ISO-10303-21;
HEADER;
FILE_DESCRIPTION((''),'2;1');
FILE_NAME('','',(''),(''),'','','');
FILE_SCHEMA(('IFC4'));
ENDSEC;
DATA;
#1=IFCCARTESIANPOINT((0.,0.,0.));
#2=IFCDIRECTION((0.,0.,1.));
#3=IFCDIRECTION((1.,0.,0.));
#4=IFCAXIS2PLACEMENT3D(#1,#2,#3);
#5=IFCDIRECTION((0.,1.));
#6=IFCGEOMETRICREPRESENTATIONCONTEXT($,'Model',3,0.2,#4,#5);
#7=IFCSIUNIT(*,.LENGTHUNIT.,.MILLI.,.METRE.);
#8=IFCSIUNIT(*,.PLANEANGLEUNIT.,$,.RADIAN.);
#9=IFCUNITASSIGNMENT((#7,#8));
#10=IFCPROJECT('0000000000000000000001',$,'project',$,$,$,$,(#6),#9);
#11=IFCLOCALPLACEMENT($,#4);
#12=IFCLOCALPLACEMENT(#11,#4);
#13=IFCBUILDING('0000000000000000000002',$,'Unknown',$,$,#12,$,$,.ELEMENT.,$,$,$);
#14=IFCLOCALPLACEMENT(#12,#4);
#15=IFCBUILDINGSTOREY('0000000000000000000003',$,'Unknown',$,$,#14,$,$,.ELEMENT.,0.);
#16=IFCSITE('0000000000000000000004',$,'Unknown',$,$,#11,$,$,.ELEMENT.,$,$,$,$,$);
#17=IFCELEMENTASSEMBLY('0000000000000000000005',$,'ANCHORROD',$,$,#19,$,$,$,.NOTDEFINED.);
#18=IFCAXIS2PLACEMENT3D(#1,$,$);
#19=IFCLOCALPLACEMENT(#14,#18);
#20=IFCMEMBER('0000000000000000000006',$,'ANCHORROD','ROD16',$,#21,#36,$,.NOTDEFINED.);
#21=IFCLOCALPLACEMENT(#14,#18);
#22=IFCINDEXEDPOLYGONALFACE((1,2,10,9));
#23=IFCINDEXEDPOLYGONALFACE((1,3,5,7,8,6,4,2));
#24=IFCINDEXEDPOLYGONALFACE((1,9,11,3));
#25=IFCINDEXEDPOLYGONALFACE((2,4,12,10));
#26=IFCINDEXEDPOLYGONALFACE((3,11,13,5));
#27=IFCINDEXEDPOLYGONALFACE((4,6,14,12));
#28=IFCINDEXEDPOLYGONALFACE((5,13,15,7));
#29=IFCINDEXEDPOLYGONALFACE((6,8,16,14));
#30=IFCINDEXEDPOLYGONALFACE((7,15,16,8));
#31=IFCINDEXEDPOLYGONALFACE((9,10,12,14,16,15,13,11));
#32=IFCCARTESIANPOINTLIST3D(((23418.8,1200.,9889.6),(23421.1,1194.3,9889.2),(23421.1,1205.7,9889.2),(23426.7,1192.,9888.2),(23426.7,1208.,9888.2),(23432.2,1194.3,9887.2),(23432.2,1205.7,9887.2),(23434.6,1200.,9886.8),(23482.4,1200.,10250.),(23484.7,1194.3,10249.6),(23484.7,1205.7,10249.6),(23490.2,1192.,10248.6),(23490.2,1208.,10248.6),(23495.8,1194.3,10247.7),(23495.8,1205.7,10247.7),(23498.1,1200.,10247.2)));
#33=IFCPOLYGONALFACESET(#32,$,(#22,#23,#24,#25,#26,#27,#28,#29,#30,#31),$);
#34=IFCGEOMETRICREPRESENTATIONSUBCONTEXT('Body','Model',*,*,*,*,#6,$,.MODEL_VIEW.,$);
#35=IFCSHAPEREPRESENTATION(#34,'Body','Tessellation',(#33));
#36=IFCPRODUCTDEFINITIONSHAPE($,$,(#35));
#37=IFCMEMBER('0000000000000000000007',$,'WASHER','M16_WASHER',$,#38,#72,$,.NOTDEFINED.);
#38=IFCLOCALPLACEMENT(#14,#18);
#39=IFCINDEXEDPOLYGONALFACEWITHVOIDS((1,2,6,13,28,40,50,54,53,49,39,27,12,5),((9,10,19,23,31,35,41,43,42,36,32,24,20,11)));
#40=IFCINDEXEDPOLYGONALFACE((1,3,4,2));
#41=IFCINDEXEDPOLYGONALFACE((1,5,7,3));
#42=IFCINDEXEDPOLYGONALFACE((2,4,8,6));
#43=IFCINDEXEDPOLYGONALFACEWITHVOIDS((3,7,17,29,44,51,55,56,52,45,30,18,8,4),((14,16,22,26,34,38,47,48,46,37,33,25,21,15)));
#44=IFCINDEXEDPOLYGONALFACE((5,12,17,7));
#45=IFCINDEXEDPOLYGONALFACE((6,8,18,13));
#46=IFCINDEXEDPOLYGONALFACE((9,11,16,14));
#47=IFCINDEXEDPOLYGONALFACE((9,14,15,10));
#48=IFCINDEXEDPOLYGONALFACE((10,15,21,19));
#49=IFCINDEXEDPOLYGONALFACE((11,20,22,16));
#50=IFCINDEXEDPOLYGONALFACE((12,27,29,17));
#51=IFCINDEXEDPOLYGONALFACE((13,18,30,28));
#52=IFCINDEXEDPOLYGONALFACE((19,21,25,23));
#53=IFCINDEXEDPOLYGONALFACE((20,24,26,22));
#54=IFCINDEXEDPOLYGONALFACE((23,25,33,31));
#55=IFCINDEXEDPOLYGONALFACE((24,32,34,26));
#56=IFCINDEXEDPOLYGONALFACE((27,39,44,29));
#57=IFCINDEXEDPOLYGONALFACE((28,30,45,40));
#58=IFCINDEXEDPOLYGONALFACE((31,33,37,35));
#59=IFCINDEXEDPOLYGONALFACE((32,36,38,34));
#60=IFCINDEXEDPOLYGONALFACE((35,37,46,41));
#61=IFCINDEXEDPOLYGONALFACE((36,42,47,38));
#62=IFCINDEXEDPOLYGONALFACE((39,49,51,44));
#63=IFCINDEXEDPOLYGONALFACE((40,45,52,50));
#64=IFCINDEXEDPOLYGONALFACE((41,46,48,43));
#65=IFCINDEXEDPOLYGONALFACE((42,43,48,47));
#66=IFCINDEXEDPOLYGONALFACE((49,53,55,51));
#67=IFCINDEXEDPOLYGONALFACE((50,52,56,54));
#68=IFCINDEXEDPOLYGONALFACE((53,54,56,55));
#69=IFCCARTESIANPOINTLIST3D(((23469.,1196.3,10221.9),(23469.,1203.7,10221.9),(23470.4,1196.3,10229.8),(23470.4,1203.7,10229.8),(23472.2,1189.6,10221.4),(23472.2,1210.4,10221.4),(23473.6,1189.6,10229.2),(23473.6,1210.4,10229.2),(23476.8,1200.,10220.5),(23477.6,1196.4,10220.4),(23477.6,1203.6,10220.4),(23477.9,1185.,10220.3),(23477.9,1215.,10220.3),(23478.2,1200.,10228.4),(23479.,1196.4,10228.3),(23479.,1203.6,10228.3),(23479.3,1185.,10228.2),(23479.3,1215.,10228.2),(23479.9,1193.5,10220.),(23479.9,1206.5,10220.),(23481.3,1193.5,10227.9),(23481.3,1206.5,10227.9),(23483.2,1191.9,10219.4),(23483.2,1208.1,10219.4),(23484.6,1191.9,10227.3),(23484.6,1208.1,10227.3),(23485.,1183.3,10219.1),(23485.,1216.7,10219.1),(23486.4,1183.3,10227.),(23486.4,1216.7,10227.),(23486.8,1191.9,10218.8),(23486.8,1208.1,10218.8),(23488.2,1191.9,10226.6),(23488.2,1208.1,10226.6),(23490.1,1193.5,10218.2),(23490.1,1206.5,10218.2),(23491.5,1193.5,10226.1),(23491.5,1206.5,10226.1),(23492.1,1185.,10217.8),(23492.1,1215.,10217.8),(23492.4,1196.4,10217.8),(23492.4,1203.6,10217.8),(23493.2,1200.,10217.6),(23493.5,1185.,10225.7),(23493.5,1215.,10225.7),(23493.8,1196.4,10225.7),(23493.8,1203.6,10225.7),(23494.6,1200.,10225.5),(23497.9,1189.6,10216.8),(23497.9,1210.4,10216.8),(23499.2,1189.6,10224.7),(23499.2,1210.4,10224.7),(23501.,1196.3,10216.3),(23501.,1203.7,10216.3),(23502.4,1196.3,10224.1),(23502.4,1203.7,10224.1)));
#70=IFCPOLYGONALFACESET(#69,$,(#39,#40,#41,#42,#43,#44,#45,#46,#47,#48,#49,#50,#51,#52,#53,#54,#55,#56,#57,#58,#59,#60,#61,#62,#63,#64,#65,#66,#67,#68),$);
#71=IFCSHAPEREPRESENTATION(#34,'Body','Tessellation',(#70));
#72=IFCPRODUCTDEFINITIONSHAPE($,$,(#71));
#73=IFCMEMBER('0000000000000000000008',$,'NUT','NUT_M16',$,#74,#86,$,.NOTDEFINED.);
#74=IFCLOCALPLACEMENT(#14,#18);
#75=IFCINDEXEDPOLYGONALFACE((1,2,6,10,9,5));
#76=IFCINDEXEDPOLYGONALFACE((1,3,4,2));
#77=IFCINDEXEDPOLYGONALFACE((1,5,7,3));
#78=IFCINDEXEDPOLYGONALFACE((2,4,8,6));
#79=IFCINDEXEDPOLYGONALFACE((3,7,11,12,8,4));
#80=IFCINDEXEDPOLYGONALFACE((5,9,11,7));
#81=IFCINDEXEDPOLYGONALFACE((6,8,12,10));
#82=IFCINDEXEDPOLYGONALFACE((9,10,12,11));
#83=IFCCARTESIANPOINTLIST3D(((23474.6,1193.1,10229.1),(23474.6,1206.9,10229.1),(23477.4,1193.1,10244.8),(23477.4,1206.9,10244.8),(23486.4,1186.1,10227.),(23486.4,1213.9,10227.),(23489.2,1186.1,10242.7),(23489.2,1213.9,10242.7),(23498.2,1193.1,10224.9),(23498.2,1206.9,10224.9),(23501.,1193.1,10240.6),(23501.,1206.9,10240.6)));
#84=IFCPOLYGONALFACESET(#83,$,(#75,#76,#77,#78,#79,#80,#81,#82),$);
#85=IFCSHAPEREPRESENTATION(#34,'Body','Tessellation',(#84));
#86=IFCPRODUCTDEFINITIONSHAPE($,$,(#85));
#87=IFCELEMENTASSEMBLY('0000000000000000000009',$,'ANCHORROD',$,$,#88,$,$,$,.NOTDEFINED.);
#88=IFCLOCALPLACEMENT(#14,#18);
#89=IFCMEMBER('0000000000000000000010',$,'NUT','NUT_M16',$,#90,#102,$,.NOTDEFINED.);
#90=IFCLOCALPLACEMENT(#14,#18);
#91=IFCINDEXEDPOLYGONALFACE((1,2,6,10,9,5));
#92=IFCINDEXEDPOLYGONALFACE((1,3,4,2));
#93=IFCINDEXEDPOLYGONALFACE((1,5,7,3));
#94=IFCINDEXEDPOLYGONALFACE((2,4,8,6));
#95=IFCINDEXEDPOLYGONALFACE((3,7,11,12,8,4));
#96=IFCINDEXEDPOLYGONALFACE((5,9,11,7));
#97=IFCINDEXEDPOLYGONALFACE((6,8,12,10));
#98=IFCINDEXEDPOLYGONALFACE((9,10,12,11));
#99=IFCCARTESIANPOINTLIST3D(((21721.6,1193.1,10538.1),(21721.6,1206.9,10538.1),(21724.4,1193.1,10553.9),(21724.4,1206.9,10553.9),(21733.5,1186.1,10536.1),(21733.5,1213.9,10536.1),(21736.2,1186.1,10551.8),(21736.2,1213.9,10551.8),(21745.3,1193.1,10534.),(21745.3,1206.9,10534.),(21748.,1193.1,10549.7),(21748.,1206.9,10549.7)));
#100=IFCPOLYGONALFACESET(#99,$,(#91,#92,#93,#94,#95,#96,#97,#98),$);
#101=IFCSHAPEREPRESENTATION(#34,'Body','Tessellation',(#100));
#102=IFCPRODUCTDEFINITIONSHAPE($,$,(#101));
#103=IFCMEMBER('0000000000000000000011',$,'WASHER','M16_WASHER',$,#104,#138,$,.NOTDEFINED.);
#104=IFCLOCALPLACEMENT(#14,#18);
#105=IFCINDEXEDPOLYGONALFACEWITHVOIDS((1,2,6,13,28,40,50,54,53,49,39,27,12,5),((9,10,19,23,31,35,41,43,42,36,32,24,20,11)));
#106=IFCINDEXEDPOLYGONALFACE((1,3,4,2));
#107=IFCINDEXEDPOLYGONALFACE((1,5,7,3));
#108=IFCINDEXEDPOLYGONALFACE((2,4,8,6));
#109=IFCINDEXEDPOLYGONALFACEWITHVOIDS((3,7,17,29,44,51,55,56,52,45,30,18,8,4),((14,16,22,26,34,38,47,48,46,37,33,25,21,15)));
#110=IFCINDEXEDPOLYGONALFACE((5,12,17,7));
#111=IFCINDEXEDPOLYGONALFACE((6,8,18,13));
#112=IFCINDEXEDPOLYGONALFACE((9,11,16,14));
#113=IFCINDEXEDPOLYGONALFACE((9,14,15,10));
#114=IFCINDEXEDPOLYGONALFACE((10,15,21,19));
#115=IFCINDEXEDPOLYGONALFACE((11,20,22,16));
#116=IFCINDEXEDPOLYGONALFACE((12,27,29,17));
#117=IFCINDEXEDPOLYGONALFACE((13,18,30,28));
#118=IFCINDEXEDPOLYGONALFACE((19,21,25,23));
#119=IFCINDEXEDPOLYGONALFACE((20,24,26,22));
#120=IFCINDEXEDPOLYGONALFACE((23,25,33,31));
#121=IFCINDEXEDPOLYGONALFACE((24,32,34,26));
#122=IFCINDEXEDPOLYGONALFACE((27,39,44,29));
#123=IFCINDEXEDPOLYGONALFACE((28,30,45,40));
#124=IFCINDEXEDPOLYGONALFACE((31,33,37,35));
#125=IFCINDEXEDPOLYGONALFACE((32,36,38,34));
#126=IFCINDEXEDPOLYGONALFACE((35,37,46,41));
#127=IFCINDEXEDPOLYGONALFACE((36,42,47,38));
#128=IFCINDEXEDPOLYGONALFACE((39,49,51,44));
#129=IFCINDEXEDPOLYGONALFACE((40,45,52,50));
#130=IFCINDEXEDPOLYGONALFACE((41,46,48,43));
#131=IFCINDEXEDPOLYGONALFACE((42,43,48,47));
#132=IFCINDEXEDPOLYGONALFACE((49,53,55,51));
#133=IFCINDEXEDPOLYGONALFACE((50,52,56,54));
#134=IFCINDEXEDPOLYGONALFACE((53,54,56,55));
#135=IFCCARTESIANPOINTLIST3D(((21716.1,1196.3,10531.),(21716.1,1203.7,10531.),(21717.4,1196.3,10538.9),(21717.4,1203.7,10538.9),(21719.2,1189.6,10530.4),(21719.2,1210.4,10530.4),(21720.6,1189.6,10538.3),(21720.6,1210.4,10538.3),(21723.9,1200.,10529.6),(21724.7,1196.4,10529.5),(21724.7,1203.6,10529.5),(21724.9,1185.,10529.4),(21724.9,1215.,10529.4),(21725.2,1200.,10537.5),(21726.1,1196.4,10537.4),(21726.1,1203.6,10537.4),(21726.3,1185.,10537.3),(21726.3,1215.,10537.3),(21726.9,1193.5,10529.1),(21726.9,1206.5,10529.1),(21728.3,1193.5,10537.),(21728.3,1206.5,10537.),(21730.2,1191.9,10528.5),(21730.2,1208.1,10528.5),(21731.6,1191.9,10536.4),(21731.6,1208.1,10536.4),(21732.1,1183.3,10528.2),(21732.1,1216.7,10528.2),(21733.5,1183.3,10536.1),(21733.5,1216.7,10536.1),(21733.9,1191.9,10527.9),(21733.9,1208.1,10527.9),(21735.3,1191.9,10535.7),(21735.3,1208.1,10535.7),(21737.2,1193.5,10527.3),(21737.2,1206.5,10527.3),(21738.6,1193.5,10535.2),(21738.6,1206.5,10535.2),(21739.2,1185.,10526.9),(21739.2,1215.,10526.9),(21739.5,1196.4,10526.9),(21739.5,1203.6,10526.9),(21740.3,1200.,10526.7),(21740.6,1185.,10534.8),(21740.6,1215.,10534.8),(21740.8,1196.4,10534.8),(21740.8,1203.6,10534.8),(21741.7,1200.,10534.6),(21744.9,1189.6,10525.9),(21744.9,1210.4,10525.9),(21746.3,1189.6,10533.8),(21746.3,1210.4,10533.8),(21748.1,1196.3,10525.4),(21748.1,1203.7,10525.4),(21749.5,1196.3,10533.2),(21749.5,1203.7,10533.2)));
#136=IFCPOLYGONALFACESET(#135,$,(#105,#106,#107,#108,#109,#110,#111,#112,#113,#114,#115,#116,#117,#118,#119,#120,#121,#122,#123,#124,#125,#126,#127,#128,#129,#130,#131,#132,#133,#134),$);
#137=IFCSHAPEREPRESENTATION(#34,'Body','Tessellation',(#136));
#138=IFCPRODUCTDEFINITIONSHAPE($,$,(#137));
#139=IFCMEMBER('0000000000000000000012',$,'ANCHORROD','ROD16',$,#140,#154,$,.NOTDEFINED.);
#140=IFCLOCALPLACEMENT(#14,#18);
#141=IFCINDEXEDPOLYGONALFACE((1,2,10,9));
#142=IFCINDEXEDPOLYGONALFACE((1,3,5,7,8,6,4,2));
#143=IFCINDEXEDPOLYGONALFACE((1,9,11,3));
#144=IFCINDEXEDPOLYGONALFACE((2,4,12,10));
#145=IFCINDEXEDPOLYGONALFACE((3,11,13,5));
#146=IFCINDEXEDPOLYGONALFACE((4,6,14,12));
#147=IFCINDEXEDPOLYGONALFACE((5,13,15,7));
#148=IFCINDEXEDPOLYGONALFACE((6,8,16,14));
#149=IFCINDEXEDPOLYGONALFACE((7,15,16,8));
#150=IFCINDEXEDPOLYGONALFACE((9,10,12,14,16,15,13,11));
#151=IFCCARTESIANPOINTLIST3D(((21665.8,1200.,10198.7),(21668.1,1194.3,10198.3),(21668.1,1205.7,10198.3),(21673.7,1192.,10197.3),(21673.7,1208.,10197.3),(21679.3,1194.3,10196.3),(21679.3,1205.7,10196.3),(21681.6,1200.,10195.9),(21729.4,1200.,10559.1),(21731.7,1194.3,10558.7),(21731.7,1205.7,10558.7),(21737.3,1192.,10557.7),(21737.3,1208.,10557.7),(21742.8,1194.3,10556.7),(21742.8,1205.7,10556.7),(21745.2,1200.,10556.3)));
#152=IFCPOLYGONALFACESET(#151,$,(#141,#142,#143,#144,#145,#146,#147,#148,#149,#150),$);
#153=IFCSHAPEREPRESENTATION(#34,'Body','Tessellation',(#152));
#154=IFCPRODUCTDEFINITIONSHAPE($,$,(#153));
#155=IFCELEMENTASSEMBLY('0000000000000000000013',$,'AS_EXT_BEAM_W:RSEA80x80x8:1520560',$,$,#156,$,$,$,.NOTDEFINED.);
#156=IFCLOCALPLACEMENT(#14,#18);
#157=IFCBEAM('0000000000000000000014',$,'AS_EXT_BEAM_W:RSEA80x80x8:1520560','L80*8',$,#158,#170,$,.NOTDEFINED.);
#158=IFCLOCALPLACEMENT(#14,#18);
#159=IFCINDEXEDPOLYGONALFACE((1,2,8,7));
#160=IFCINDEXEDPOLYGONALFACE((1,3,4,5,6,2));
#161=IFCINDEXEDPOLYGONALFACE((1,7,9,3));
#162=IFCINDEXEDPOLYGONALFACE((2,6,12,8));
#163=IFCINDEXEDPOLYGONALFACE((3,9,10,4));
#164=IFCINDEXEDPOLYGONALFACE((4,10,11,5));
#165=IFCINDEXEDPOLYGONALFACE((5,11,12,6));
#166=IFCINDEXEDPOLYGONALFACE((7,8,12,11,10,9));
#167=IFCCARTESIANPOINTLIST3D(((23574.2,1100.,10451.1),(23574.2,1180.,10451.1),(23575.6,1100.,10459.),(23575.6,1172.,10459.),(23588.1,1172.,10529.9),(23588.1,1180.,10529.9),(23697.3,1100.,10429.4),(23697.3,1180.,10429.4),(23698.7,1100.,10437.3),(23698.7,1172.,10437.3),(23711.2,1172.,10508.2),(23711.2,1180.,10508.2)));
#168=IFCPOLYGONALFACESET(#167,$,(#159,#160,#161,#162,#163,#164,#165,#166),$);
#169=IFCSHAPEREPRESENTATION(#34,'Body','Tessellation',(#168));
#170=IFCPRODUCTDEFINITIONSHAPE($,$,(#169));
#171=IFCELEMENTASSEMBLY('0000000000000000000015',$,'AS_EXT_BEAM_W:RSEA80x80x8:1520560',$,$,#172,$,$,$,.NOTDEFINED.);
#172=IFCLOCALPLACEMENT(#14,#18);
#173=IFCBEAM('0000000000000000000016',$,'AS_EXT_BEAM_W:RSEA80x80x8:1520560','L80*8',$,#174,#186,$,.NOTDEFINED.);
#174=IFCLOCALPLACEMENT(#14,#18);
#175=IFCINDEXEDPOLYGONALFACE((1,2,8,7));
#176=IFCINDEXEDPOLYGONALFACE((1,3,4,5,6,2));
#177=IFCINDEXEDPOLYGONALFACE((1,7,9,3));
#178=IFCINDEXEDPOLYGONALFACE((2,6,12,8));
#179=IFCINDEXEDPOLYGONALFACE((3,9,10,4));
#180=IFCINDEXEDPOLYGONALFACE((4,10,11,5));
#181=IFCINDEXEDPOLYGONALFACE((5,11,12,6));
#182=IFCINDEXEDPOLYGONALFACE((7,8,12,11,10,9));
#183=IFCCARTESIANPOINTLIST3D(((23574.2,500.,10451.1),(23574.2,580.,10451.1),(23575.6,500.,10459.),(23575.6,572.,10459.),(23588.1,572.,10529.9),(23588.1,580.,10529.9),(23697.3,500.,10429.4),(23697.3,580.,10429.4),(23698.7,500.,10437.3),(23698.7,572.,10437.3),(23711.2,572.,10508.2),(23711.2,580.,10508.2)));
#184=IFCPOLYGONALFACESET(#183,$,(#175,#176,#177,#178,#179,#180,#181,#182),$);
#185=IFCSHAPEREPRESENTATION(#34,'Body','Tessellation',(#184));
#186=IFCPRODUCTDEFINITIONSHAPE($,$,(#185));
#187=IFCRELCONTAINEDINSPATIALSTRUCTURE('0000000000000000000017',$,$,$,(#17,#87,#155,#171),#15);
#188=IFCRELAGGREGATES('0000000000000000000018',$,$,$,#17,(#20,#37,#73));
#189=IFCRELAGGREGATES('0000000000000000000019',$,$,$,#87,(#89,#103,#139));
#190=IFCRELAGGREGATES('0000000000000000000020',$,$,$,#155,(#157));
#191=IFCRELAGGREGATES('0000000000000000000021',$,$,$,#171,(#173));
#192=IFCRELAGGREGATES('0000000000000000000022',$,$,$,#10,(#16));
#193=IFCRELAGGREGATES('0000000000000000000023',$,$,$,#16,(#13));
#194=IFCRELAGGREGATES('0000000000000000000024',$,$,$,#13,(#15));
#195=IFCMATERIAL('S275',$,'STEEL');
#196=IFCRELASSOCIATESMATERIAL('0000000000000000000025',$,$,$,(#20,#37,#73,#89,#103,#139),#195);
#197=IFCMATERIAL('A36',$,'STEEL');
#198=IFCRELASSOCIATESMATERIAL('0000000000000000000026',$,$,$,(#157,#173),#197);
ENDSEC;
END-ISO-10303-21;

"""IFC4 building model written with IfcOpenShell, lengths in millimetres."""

from ifc_helpers import new_model, si_unit, direction, frame, origin_with_axes, place, context, subcontext, project, spatial, line, indexed_curve, outline, extrude, material, element, aggregate, save


model = new_model("IFC4")

# Units and contexts
model_context = context("Model", 3, precision=0.2, world=origin_with_axes(), true_north=direction((0.0, 1.0)))
body_context = subcontext(model_context, "Body", "Model", "MODEL_VIEW")
ifc_project = project(units=[si_unit("LENGTHUNIT", "METRE", prefix="MILLI"), si_unit("PLANEANGLEUNIT", "RADIAN")], contexts=[model_context])

# Site, building, storey
site_placement = place(None, origin_with_axes())
site = spatial("IfcSite", under=ifc_project, at=site_placement, Name="Unknown", CompositionType="ELEMENT")
building_placement = place(site_placement, origin_with_axes())
building = spatial("IfcBuilding", under=site, at=building_placement, Name="Unknown", CompositionType="ELEMENT")
storey_placement = place(building_placement, origin_with_axes())
storey = spatial("IfcBuildingStorey", under=building, at=storey_placement, Name="Unknown", CompositionType="ELEMENT", Elevation=0.0)

# Element assemblies, members
assembly_1_placement = place(storey_placement, frame((23490.2, 1200.0, 10248.6), z_axis=(0.0, -1.0, 0.0), x_axis=(-0.173648, 0.0, -0.984808)))
assembly_1 = element("IfcElementAssembly", 1, at=assembly_1_placement, inside=storey, Name="ANCHORROD", PredefinedType="NOTDEFINED")
ifc_material_1 = material(Name="S275", Category="STEEL")
member_1_placement = place(assembly_1_placement, origin_with_axes())
member_1 = element("IfcMember", 2, at=member_1_placement, material=ifc_material_1, Name="ANCHORROD", Description="ROD16", PredefinedType="NOTDEFINED", context=body_context, shape_type="SolidModel", body=[
    extrude(outline(indexed_curve([(8.0, 0.0), (5.7, 5.7), (0.0, 8.0), (-5.7, 5.7), (-8.0, 0.0), (-5.7, -5.7), (0.0, -8.0), (5.7, -5.7)], segments=[line(1, 2, 3, 4, 5, 6, 7, 8, 1)])), frame((0.0, 0.0, 0.0), z_axis=(-1.0, 0.0, 0.0), x_axis=(0.0, 0.0, 1.0)), (0.0, 0.0, -1.0), 366.0),
])
member_2_placement = place(assembly_1_placement, frame((22.0, 0.0, 0.0), z_axis=(0.0, 0.0, 1.0), x_axis=(1.0, 0.0, 0.0)))
member_2 = element("IfcMember", 3, at=member_2_placement, material=ifc_material_1, Name="WASHER", Description="M16_WASHER", PredefinedType="NOTDEFINED", context=body_context, shape_type="SolidModel", body=[
    extrude(outline(indexed_curve([(16.7, 0.0), (15.0, 7.2), (10.4, 13.0), (3.7, 16.3), (-3.7, 16.3), (-10.4, 13.0), (-15.0, 7.2), (-16.7, 0.0), (-15.0, -7.2), (-10.4, -13.0), (-3.7, -16.3), (3.7, -16.3), (10.4, -13.0), (15.0, -7.2)], segments=[line(1, 2, 3, 4, 5, 6, 7, 8, 9, 10, 11, 12, 13, 14, 1)]), holes=[indexed_curve([(0.0, 8.3), (3.6, 7.5), (6.5, 5.2), (8.1, 1.9), (8.1, -1.9), (6.5, -5.2), (3.6, -7.5), (0.0, -8.3), (-3.6, -7.5), (-6.5, -5.2), (-8.1, -1.9), (-8.1, 1.9), (-6.5, 5.2), (-3.6, 7.5)], segments=[line(1, 2, 3, 4, 5, 6, 7, 8, 9, 10, 11, 12, 13, 14, 1)])]), frame((0.0, 0.0, 0.0), z_axis=(-1.0, 0.0, 0.0), x_axis=(0.0, 0.0, 1.0)), (0.0, 0.0, -1.0), 8.0),
])
member_3_placement = place(assembly_1_placement, frame((6.0, 0.0, 0.0), z_axis=(0.0, 0.0, 1.0), x_axis=(1.0, 0.0, 0.0)))
member_3 = element("IfcMember", 4, at=member_3_placement, material=ifc_material_1, Name="NUT", Description="NUT_M16", PredefinedType="NOTDEFINED", context=body_context, shape_type="SolidModel", body=[
    extrude(outline(indexed_curve([(6.9, -12.0), (13.9, 0.0), (6.9, 12.0), (-6.9, 12.0), (-13.9, 0.0), (-6.9, -12.0)], segments=[line(1, 2, 3, 4, 5, 6, 1)])), frame((0.0, 0.0, 0.0), z_axis=(-1.0, 0.0, 0.0), x_axis=(0.0, 0.0, 1.0)), (0.0, 0.0, -1.0), 16.0),
])
aggregate(assembly_1, [member_1, member_2, member_3])
assembly_2_placement = place(storey_placement, frame((21737.3, 1200.0, 10557.7), z_axis=(0.0, -1.0, 0.0), x_axis=(-0.173648, 0.0, -0.984808)))
assembly_2 = element("IfcElementAssembly", 5, at=assembly_2_placement, inside=storey, Name="ANCHORROD", PredefinedType="NOTDEFINED")
member_4_placement = place(assembly_2_placement, frame((6.0, 0.0, 0.0), z_axis=(0.0, 0.0, 1.0), x_axis=(1.0, 0.0, 0.0)))
member_4 = element("IfcMember", 6, at=member_4_placement, material=ifc_material_1, Name="NUT", Description="NUT_M16", PredefinedType="NOTDEFINED", context=body_context, shape_type="SolidModel", body=[
    extrude(outline(indexed_curve([(6.9, -12.0), (13.9, 0.0), (6.9, 12.0), (-6.9, 12.0), (-13.9, 0.0), (-6.9, -12.0)], segments=[line(1, 2, 3, 4, 5, 6, 1)])), frame((0.0, 0.0, 0.0), z_axis=(-1.0, 0.0, 0.0), x_axis=(0.0, 0.0, 1.0)), (0.0, 0.0, -1.0), 16.0),
])
member_5_placement = place(assembly_2_placement, frame((22.0, 0.0, 0.0), z_axis=(0.0, 0.0, 1.0), x_axis=(1.0, 0.0, 0.0)))
member_5 = element("IfcMember", 7, at=member_5_placement, material=ifc_material_1, Name="WASHER", Description="M16_WASHER", PredefinedType="NOTDEFINED", context=body_context, shape_type="SolidModel", body=[
    extrude(outline(indexed_curve([(16.7, 0.0), (15.0, 7.2), (10.4, 13.0), (3.7, 16.3), (-3.7, 16.3), (-10.4, 13.0), (-15.0, 7.2), (-16.7, 0.0), (-15.0, -7.2), (-10.4, -13.0), (-3.7, -16.3), (3.7, -16.3), (10.4, -13.0), (15.0, -7.2)], segments=[line(1, 2, 3, 4, 5, 6, 7, 8, 9, 10, 11, 12, 13, 14, 1)]), holes=[indexed_curve([(0.0, 8.3), (3.6, 7.5), (6.5, 5.2), (8.1, 1.9), (8.1, -1.9), (6.5, -5.2), (3.6, -7.5), (0.0, -8.3), (-3.6, -7.5), (-6.5, -5.2), (-8.1, -1.9), (-8.1, 1.9), (-6.5, 5.2), (-3.6, 7.5)], segments=[line(1, 2, 3, 4, 5, 6, 7, 8, 9, 10, 11, 12, 13, 14, 1)])]), frame((0.0, 0.0, 0.0), z_axis=(-1.0, 0.0, 0.0), x_axis=(0.0, 0.0, 1.0)), (0.0, 0.0, -1.0), 8.0),
])
member_6_placement = place(assembly_2_placement, origin_with_axes())
member_6 = element("IfcMember", 8, at=member_6_placement, material=ifc_material_1, Name="ANCHORROD", Description="ROD16", PredefinedType="NOTDEFINED", context=body_context, shape_type="SolidModel", body=[
    extrude(outline(indexed_curve([(8.0, 0.0), (5.7, 5.7), (0.0, 8.0), (-5.7, 5.7), (-8.0, 0.0), (-5.7, -5.7), (0.0, -8.0), (5.7, -5.7)], segments=[line(1, 2, 3, 4, 5, 6, 7, 8, 1)])), frame((0.0, 0.0, 0.0), z_axis=(-1.0, 0.0, 0.0), x_axis=(0.0, 0.0, 1.0)), (0.0, 0.0, -1.0), 366.0),
])
aggregate(assembly_2, [member_4, member_5, member_6])

# Element assemblies, beams
assembly_3_placement = place(storey_placement, frame((23581.1, 1140.0, 10490.5), z_axis=(0.0, -1.0, 0.0), x_axis=(0.984808, 0.0, -0.173648)))
assembly_3 = element("IfcElementAssembly", 9, at=assembly_3_placement, inside=storey, Name="AS_EXT_BEAM_W:RSEA80x80x8:1520560", PredefinedType="NOTDEFINED")
ifc_material_2 = material(Name="A36", Category="STEEL")
beam_1_placement = place(assembly_3_placement, origin_with_axes())
beam_1 = element("IfcBeam", 10, at=beam_1_placement, material=ifc_material_2, Name="AS_EXT_BEAM_W:RSEA80x80x8:1520560", Description="L80*8", PredefinedType="NOTDEFINED", context=body_context, shape_type="SolidModel", body=[
    extrude(outline(indexed_curve([(-40.0, -40.0), (40.0, -40.0), (40.0, -32.0), (-32.0, -32.0), (-32.0, 40.0), (-40.0, 40.0)], segments=[line(1, 2, 3, 4, 5, 6, 1)])), frame((0.0, 0.0, 0.0), z_axis=(-1.0, 0.0, 0.0), x_axis=(0.0, 0.0, 1.0)), (0.0, 0.0, -1.0), 125.0),
])
assembly_4_placement = place(storey_placement, frame((23581.1, 540.0, 10490.5), z_axis=(0.0, -1.0, 0.0), x_axis=(0.984808, 0.0, -0.173648)))
assembly_4 = element("IfcElementAssembly", 11, at=assembly_4_placement, inside=storey, Name="AS_EXT_BEAM_W:RSEA80x80x8:1520560", PredefinedType="NOTDEFINED")
beam_2_placement = place(assembly_4_placement, origin_with_axes())
beam_2 = element("IfcBeam", 12, at=beam_2_placement, material=ifc_material_2, Name="AS_EXT_BEAM_W:RSEA80x80x8:1520560", Description="L80*8", PredefinedType="NOTDEFINED", context=body_context, shape_type="SolidModel", body=[
    extrude(outline(indexed_curve([(-40.0, -40.0), (40.0, -40.0), (40.0, -32.0), (-32.0, -32.0), (-32.0, 40.0), (-40.0, 40.0)], segments=[line(1, 2, 3, 4, 5, 6, 1)])), frame((0.0, 0.0, 0.0), z_axis=(-1.0, 0.0, 0.0), x_axis=(0.0, 0.0, 1.0)), (0.0, 0.0, -1.0), 125.0),
])

aggregate(assembly_3, [beam_1])
aggregate(assembly_4, [beam_2])

save(model, "model.ifc")
